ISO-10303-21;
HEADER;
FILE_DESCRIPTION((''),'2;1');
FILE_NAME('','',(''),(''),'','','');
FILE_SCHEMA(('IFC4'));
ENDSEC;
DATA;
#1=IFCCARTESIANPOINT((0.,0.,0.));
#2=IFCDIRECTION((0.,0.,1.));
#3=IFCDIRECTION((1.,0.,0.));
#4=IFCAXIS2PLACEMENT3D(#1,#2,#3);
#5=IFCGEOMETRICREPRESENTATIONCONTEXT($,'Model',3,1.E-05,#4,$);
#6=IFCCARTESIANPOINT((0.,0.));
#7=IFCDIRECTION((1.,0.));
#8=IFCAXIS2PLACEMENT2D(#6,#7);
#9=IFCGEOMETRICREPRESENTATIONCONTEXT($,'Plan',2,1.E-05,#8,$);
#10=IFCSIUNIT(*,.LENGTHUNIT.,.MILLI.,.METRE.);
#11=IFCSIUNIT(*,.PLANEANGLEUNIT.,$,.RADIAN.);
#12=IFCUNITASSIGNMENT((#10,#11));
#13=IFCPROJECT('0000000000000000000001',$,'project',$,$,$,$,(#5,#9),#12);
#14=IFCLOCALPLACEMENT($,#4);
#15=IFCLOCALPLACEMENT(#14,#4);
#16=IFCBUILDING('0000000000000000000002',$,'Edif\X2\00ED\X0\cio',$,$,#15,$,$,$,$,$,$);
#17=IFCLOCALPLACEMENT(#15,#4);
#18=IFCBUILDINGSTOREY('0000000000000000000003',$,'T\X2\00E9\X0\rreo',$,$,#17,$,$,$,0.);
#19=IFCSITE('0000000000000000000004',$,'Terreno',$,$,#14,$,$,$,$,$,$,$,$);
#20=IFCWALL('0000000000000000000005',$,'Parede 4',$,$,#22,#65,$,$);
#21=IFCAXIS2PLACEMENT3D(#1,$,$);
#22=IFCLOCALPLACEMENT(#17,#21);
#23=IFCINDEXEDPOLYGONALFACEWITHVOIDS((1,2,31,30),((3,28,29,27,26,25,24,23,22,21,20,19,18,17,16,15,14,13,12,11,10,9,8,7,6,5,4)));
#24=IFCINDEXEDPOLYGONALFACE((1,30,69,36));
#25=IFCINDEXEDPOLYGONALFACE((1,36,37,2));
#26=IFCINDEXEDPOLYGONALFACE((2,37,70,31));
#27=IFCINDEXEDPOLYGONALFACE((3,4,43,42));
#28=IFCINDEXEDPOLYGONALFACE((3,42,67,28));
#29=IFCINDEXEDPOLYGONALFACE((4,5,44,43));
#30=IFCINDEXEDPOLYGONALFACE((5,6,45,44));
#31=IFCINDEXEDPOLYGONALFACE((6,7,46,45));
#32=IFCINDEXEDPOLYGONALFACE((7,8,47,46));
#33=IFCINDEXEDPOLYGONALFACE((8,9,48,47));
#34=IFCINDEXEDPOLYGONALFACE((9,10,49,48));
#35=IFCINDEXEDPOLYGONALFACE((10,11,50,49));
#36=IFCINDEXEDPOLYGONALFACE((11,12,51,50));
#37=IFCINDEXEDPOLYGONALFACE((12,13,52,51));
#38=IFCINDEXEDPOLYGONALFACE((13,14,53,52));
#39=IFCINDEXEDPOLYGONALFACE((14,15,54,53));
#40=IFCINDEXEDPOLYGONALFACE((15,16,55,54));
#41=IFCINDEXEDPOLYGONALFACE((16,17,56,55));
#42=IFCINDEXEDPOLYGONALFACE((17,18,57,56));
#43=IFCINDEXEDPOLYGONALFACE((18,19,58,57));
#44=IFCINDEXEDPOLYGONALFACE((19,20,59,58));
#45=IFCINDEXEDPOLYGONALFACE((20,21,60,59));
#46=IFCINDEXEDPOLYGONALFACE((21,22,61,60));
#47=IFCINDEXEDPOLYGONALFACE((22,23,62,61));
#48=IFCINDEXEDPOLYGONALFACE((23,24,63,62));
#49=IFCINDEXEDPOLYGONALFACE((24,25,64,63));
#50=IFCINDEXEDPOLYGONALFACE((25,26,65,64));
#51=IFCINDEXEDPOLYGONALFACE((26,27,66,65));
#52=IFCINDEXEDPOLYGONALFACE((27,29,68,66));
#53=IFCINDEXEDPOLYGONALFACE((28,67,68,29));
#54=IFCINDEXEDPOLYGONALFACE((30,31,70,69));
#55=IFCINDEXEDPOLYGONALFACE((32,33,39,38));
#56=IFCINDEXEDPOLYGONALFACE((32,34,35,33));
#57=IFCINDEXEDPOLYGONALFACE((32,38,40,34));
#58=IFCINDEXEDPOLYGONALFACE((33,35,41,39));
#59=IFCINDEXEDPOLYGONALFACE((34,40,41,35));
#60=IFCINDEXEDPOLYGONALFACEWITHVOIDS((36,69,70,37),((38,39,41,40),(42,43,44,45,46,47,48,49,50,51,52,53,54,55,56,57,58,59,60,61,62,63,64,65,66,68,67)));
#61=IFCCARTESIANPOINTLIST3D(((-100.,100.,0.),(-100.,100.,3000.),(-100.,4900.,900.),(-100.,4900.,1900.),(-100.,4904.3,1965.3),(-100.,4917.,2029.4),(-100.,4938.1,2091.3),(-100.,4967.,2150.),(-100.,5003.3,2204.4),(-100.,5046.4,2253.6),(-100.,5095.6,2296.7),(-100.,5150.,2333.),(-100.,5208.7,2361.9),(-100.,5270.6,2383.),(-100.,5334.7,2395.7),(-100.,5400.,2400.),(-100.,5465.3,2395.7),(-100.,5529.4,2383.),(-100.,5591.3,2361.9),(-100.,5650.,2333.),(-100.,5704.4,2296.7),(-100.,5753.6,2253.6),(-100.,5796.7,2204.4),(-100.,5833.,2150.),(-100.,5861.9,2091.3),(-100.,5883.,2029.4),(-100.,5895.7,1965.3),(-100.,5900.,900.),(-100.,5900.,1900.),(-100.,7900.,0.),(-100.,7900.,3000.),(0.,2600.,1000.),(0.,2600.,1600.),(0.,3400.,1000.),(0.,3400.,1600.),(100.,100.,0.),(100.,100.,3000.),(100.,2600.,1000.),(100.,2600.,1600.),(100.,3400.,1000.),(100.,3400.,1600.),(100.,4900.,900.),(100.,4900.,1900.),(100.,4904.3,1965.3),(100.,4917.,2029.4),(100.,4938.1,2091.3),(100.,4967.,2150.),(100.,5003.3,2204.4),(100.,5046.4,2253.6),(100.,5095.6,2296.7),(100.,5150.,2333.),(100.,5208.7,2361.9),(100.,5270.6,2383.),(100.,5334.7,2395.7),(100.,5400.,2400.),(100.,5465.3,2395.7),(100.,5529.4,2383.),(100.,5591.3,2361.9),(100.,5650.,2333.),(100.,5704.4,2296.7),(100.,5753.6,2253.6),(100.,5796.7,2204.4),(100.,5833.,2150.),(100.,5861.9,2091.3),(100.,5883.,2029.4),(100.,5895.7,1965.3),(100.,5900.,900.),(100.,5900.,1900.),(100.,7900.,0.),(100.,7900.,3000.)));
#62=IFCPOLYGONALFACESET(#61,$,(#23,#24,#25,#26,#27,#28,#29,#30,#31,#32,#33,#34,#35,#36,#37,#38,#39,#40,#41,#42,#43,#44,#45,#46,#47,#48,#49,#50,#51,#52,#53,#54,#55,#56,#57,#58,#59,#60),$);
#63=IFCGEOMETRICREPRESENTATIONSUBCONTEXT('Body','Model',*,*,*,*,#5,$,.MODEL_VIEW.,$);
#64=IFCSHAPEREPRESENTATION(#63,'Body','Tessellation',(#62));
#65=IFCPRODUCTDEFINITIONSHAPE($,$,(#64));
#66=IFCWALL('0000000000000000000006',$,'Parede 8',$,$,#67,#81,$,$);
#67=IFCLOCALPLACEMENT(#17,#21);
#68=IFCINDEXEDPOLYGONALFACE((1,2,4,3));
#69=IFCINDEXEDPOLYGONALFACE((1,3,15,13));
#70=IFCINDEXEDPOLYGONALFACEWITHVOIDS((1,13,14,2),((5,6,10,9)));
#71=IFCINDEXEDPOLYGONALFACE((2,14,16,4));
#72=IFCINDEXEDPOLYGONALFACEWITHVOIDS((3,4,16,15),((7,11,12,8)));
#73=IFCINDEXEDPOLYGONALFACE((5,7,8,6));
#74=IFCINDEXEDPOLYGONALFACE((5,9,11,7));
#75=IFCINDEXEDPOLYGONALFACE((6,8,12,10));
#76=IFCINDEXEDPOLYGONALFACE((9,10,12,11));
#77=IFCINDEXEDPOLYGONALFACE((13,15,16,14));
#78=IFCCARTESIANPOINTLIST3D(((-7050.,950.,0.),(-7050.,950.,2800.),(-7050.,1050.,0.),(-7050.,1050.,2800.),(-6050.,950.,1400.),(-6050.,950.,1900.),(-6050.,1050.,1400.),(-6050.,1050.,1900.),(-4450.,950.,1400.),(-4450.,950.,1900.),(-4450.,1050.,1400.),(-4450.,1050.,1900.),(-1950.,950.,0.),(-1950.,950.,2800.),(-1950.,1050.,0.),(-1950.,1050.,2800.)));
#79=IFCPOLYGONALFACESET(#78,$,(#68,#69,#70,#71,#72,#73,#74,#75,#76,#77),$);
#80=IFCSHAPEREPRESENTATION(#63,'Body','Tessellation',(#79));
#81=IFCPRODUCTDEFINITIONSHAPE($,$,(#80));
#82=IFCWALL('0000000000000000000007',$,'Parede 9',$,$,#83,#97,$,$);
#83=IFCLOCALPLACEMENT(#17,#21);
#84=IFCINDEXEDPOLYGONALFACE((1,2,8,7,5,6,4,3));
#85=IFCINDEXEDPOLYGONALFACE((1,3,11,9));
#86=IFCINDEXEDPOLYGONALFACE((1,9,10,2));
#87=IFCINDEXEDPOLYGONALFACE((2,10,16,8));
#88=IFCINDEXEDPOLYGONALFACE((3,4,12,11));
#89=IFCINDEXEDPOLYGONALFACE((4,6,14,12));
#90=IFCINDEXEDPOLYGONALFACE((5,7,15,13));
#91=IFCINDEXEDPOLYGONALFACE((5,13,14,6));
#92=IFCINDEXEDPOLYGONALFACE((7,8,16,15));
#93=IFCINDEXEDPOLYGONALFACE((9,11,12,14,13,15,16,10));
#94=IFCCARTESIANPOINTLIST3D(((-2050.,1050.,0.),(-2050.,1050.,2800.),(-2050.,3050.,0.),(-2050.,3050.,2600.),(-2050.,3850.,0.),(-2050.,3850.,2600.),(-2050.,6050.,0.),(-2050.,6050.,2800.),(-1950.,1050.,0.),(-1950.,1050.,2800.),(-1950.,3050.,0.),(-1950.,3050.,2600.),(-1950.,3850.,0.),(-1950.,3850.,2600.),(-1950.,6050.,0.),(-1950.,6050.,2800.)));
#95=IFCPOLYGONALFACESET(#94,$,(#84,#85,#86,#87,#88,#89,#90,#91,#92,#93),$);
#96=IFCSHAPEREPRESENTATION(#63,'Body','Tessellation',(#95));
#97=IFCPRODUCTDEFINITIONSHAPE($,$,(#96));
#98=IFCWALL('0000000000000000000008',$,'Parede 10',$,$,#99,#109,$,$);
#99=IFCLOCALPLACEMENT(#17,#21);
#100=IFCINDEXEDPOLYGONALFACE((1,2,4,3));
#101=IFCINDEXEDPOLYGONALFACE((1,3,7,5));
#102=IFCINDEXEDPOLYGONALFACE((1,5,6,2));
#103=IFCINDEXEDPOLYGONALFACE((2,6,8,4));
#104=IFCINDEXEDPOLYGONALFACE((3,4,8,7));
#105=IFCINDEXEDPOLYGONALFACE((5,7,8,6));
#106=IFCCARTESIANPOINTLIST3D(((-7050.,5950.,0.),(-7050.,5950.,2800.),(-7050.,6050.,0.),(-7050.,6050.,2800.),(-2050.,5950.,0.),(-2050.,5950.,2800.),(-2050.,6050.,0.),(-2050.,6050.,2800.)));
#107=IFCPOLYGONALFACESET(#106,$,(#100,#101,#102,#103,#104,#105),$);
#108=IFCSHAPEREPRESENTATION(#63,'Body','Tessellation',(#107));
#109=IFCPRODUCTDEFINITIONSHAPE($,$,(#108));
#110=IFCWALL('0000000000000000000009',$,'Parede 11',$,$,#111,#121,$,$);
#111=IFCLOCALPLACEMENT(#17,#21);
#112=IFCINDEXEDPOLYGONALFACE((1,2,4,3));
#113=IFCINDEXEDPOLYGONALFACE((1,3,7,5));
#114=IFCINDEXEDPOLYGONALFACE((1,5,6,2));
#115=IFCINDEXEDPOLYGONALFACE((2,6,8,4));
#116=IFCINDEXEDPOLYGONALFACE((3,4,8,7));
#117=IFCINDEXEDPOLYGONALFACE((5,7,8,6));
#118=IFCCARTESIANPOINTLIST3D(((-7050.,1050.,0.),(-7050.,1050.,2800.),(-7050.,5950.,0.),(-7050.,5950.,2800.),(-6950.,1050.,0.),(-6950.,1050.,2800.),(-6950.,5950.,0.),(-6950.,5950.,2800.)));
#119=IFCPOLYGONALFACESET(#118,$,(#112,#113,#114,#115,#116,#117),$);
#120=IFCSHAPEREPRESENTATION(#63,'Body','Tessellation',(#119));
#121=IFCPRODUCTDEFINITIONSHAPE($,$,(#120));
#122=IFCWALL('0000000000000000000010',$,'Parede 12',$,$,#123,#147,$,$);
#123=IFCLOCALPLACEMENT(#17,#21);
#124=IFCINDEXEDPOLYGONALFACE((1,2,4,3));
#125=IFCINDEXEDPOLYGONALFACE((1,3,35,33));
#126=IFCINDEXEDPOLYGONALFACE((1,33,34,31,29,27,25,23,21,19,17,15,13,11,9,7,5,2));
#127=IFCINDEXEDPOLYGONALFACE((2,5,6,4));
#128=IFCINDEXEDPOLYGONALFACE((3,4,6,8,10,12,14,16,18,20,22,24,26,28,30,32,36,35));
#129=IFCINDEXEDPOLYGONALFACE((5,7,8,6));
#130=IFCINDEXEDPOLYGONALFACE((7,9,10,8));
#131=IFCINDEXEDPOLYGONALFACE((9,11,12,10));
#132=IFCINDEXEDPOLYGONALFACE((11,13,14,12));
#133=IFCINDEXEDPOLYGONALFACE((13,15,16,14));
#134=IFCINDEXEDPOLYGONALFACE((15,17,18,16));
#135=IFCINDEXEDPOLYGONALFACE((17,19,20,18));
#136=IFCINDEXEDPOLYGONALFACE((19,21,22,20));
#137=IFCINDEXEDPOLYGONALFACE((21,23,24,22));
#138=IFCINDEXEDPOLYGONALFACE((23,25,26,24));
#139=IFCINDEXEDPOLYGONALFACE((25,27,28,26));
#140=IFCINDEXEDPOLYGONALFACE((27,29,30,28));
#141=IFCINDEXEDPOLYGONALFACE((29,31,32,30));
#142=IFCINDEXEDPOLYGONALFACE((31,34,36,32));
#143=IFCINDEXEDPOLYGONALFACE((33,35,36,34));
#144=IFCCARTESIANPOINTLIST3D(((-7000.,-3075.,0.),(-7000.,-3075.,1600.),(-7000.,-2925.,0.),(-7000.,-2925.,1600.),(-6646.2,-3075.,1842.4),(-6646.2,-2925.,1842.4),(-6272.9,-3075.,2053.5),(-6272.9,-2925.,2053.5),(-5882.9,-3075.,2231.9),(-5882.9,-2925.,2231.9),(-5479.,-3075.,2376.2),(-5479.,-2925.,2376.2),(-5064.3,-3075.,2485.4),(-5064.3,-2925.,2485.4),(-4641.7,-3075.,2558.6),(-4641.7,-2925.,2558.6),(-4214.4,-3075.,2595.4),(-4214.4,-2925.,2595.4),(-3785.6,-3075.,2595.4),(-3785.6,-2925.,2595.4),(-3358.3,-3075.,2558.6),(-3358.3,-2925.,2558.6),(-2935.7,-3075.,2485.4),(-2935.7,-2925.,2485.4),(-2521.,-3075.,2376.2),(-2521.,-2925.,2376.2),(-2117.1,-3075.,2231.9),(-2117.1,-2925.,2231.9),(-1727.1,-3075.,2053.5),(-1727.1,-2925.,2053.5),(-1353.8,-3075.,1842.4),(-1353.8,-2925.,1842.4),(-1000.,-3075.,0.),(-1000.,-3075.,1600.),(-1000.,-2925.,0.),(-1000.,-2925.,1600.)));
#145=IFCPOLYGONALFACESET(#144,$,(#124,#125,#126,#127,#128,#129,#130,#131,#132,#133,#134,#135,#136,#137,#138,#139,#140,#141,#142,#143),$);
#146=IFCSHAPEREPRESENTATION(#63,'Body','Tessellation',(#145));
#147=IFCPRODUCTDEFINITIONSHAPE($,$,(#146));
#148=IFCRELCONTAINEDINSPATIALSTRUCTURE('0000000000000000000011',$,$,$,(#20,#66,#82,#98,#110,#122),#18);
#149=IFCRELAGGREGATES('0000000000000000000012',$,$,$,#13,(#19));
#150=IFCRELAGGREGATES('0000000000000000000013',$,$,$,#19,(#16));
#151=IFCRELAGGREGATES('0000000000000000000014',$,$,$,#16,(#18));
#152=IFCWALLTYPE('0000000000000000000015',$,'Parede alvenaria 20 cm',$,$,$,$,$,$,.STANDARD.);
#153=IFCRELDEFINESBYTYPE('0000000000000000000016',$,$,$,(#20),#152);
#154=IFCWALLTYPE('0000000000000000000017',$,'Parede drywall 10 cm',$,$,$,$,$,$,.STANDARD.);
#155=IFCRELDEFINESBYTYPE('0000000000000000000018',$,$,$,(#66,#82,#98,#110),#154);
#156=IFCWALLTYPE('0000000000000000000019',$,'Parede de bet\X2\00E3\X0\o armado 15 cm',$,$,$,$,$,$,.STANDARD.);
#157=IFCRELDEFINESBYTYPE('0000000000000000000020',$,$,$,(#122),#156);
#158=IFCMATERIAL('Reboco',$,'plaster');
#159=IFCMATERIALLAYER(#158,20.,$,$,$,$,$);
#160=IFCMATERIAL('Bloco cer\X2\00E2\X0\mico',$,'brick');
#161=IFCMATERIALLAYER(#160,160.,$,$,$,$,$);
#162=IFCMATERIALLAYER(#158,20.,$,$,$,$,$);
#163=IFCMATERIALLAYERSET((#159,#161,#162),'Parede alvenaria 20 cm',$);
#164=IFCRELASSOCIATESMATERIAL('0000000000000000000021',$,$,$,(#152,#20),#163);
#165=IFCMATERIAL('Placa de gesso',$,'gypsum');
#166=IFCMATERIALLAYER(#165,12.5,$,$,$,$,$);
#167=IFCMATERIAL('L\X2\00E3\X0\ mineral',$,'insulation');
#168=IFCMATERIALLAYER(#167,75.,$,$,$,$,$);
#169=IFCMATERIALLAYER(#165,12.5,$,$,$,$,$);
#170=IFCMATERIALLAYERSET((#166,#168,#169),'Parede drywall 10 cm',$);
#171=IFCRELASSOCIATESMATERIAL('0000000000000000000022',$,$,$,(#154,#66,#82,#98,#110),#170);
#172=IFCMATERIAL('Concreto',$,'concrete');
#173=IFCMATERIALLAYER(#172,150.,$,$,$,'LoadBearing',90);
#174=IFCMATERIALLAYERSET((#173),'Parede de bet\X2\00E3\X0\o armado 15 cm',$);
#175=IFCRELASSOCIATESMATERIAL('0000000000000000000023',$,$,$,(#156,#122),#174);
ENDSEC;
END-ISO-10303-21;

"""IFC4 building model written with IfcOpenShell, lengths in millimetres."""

from ifc_helpers import new_model, si_unit, frame, origin_with_axes, origin_2d_with_axis, place, context, subcontext, project, spatial, indexed_curve, outline, extrude, material, layer, layer_set, layer_usage, type_object, element, save


model = new_model("IFC4")

# Units and contexts
model_context = context("Model", 3, precision=1e-05, world=origin_with_axes())
plan_context = context("Plan", 2, precision=1e-05, world=origin_2d_with_axis())
body_context = subcontext(model_context, "Body", "Model", "MODEL_VIEW")
ifc_project = project(units=[si_unit("LENGTHUNIT", "METRE", prefix="MILLI"), si_unit("PLANEANGLEUNIT", "RADIAN")], contexts=[model_context, plan_context])

# Site, building, storey
site_placement = place(None, origin_with_axes())
site = spatial("IfcSite", under=ifc_project, at=site_placement, Name="Terreno")
building_placement = place(site_placement, origin_with_axes())
building = spatial("IfcBuilding", under=site, at=building_placement, Name="Edifício")
storey_placement = place(building_placement, origin_with_axes())
storey = spatial("IfcBuildingStorey", under=building, at=storey_placement, Name="Térreo", Elevation=0.0)

# Shared definitions
ifc_material_1 = material(Name="Concreto", Category="concrete")

# Shared definitions
ifc_material_2 = material(Name="Reboco", Category="plaster")
ifc_layer_1 = layer(ifc_material_2, 20.0)
ifc_material_3 = material(Name="Bloco cerâmico", Category="brick")
ifc_layer_2 = layer(ifc_material_3, 160.0)
ifc_layer_3 = layer(ifc_material_2, 20.0)
ifc_layer_set_1 = layer_set([ifc_layer_1, ifc_layer_2, ifc_layer_3], Name="Parede alvenaria 20 cm")
wall_type_1 = type_object("IfcWallType", Name="Parede alvenaria 20 cm", PredefinedType="STANDARD", material=ifc_layer_set_1)

# Wall, openings
ifc_layer_usage_1 = layer_usage(ifc_layer_set_1, "AXIS2", "POSITIVE", -100.0)
wall_1_placement = place(storey_placement, frame((0.0, 7900.0, 0.0), z_axis=(0.0, 0.0, 1.0), x_axis=(0.0, -1.0, 0.0)))
wall_1 = element("IfcWall", 1, at=wall_1_placement, inside=storey, type_object=wall_type_1, material=ifc_layer_usage_1, Name="Parede 4", context=body_context, shape_type="SweptSolid", body=[
    extrude(outline(indexed_curve([(0.0, 0.0), (0.0, 200.0), (7800.0, 200.0), (7800.0, 0.0), (0.0, 0.0)], self_intersect=False)), frame((0.0, -100.0, 0.0), z_axis=(0.0, 0.0, 1.0), x_axis=(1.0, 0.0, 0.0)), (0.0, 0.0, 1.0), 3000.0),
])
opening_1_placement = place(wall_1_placement, frame((2000.0, -110.0, 900.0), z_axis=(0.0, 0.0, 1.0), x_axis=(1.0, 0.0, 0.0)))
element("IfcOpeningElement", 2, at=opening_1_placement, cuts=wall_1, context=body_context, shape_type="SweptSolid", body=[
    extrude(outline(indexed_curve([(0.0, 0.0), (1000.0, 0.0), (1000.0, 1000.0), (995.7, 1065.3), (983.0, 1129.4), (961.9, 1191.3), (933.0, 1250.0), (896.7, 1304.4), (853.6, 1353.6), (804.4, 1396.7), (750.0, 1433.0), (691.3, 1461.9), (629.4, 1483.0), (565.3, 1495.7), (500.0, 1500.0), (434.7, 1495.7), (370.6, 1483.0), (308.7, 1461.9), (250.0, 1433.0), (195.6, 1396.7), (146.4, 1353.6), (103.3, 1304.4), (67.0, 1250.0), (38.1, 1191.3), (17.0, 1129.4), (4.3, 1065.3), (0.0, 1000.0), (0.0, 0.0)], self_intersect=False)), frame((0.0, 220.0, 0.0), z_axis=(0.0, -1.0, 0.0), x_axis=(1.0, 0.0, 0.0)), (0.0, 0.0, 1.0), 220.0),
])
opening_2_placement = place(wall_1_placement, frame((4500.0, 0.0, 1000.0), z_axis=(0.0, 0.0, 1.0), x_axis=(1.0, 0.0, 0.0)))
element("IfcOpeningElement", 3, at=opening_2_placement, cuts=wall_1, PredefinedType="RECESS", context=body_context, shape_type="SweptSolid", body=[
    extrude(outline(indexed_curve([(0.0, 0.0), (0.0, 110.0), (800.0, 110.0), (800.0, 0.0), (0.0, 0.0)], self_intersect=False)), origin_with_axes(), (0.0, 0.0, 1.0), 600.0),
])

# Walls, openings
ifc_material_4 = material(Name="Placa de gesso", Category="gypsum")
ifc_layer_4 = layer(ifc_material_4, 12.5)
ifc_material_5 = material(Name="Lã mineral", Category="insulation")
ifc_layer_5 = layer(ifc_material_5, 75.0)
ifc_layer_6 = layer(ifc_material_4, 12.5)
ifc_layer_set_2 = layer_set([ifc_layer_4, ifc_layer_5, ifc_layer_6], Name="Parede drywall 10 cm")
ifc_layer_usage_2 = layer_usage(ifc_layer_set_2, "AXIS2", "POSITIVE", -50.0)
wall_type_2 = type_object("IfcWallType", Name="Parede drywall 10 cm", PredefinedType="STANDARD", material=ifc_layer_set_2)
wall_2_placement = place(storey_placement, frame((-7050.0, 1000.0, 0.0), z_axis=(0.0, 0.0, 1.0), x_axis=(1.0, 0.0, 0.0)))
wall_2 = element("IfcWall", 4, at=wall_2_placement, inside=storey, type_object=wall_type_2, material=ifc_layer_usage_2, Name="Parede 8", context=body_context, shape_type="SweptSolid", body=[
    extrude(outline(indexed_curve([(0.0, 0.0), (0.0, 100.0), (5100.0, 100.0), (5100.0, 0.0), (0.0, 0.0)], self_intersect=False)), frame((0.0, -50.0, 0.0), z_axis=(0.0, 0.0, 1.0), x_axis=(1.0, 0.0, 0.0)), (0.0, 0.0, 1.0), 2800.0),
])
opening_3_placement = place(wall_2_placement, frame((1000.0, -60.0, 1400.0), z_axis=(0.0, 0.0, 1.0), x_axis=(1.0, 0.0, 0.0)))
element("IfcOpeningElement", 5, at=opening_3_placement, cuts=wall_2, PredefinedType="OPENING", context=body_context, shape_type="SweptSolid", body=[
    extrude(outline(indexed_curve([(0.0, 0.0), (0.0, 120.0), (1600.0, 120.0), (1600.0, 0.0), (0.0, 0.0)], self_intersect=False)), origin_with_axes(), (0.0, 0.0, 1.0), 500.0),
])
ifc_layer_usage_3 = layer_usage(ifc_layer_set_2, "AXIS2", "POSITIVE", -50.0)
wall_3_placement = place(storey_placement, frame((-2000.0, 1050.0, 0.0), z_axis=(0.0, 0.0, 1.0), x_axis=(0.0, 1.0, 0.0)))
wall_3 = element("IfcWall", 6, at=wall_3_placement, inside=storey, type_object=wall_type_2, material=ifc_layer_usage_3, Name="Parede 9", context=body_context, shape_type="SweptSolid", body=[
    extrude(outline(indexed_curve([(0.0, 0.0), (0.0, 100.0), (5000.0, 100.0), (5000.0, 0.0), (0.0, 0.0)], self_intersect=False)), frame((0.0, -50.0, 0.0), z_axis=(0.0, 0.0, 1.0), x_axis=(1.0, 0.0, 0.0)), (0.0, 0.0, 1.0), 2800.0),
])
opening_4_placement = place(wall_3_placement, frame((2000.0, -60.0, 0.0), z_axis=(0.0, 0.0, 1.0), x_axis=(1.0, 0.0, 0.0)))
element("IfcOpeningElement", 7, at=opening_4_placement, cuts=wall_3, context=body_context, shape_type="SweptSolid", body=[
    extrude(outline(indexed_curve([(0.0, 0.0), (0.0, 120.0), (800.0, 120.0), (800.0, 0.0), (0.0, 0.0)], self_intersect=False)), origin_with_axes(), (0.0, 0.0, 1.0), 2600.0),
])

# Walls
ifc_layer_usage_4 = layer_usage(ifc_layer_set_2, "AXIS2", "POSITIVE", -50.0)
wall_4_placement = place(storey_placement, frame((-2050.0, 6000.0, 0.0), z_axis=(0.0, 0.0, 1.0), x_axis=(-1.0, 0.0, 0.0)))
element("IfcWall", 8, at=wall_4_placement, inside=storey, type_object=wall_type_2, material=ifc_layer_usage_4, Name="Parede 10", context=body_context, shape_type="SweptSolid", body=[
    extrude(outline(indexed_curve([(0.0, 0.0), (0.0, 100.0), (5000.0, 100.0), (5000.0, 0.0), (0.0, 0.0)], self_intersect=False)), frame((0.0, -50.0, 0.0), z_axis=(0.0, 0.0, 1.0), x_axis=(1.0, 0.0, 0.0)), (0.0, 0.0, 1.0), 2800.0),
])
ifc_layer_usage_5 = layer_usage(ifc_layer_set_2, "AXIS2", "POSITIVE", -50.0)
wall_5_placement = place(storey_placement, frame((-7000.0, 5950.0, 0.0), z_axis=(0.0, 0.0, 1.0), x_axis=(0.0, -1.0, 0.0)))
element("IfcWall", 9, at=wall_5_placement, inside=storey, type_object=wall_type_2, material=ifc_layer_usage_5, Name="Parede 11", context=body_context, shape_type="SweptSolid", body=[
    extrude(outline(indexed_curve([(0.0, 0.0), (0.0, 100.0), (4900.0, 100.0), (4900.0, 0.0), (0.0, 0.0)], self_intersect=False)), frame((0.0, -50.0, 0.0), z_axis=(0.0, 0.0, 1.0), x_axis=(1.0, 0.0, 0.0)), (0.0, 0.0, 1.0), 2800.0),
])
ifc_layer_7 = layer(ifc_material_1, 150.0, Category="LoadBearing", Priority=90)
ifc_layer_set_3 = layer_set([ifc_layer_7], Name="Parede de betão armado 15 cm")
ifc_layer_usage_6 = layer_usage(ifc_layer_set_3, "AXIS2", "POSITIVE", -75.0)
wall_type_3 = type_object("IfcWallType", Name="Parede de betão armado 15 cm", PredefinedType="STANDARD", material=ifc_layer_set_3)
wall_6_placement = place(storey_placement, frame((-7000.0, -3000.0, 0.0), z_axis=(0.0, 0.0, 1.0), x_axis=(1.0, 0.0, 0.0)))
element("IfcWall", 10, at=wall_6_placement, inside=storey, type_object=wall_type_3, material=ifc_layer_usage_6, Name="Parede 12", context=body_context, shape_type="SweptSolid", body=[
    extrude(outline(indexed_curve([(0.0, 0.0), (6000.0, 0.0), (6000.0, 1600.0), (5646.2, 1842.4), (5272.9, 2053.5), (4882.9, 2231.9), (4479.0, 2376.2), (4064.3, 2485.4), (3641.7, 2558.6), (3214.4, 2595.4), (2785.6, 2595.4), (2358.3, 2558.6), (1935.7, 2485.4), (1521.0, 2376.2), (1117.1, 2231.9), (727.1, 2053.5), (353.8, 1842.4), (0.0, 1600.0), (0.0, 0.0)], self_intersect=False)), frame((0.0, 75.0, 0.0), z_axis=(0.0, -1.0, 0.0), x_axis=(1.0, 0.0, 0.0)), (0.0, 0.0, 1.0), 150.0),
])

save(model, "model.ifc")
